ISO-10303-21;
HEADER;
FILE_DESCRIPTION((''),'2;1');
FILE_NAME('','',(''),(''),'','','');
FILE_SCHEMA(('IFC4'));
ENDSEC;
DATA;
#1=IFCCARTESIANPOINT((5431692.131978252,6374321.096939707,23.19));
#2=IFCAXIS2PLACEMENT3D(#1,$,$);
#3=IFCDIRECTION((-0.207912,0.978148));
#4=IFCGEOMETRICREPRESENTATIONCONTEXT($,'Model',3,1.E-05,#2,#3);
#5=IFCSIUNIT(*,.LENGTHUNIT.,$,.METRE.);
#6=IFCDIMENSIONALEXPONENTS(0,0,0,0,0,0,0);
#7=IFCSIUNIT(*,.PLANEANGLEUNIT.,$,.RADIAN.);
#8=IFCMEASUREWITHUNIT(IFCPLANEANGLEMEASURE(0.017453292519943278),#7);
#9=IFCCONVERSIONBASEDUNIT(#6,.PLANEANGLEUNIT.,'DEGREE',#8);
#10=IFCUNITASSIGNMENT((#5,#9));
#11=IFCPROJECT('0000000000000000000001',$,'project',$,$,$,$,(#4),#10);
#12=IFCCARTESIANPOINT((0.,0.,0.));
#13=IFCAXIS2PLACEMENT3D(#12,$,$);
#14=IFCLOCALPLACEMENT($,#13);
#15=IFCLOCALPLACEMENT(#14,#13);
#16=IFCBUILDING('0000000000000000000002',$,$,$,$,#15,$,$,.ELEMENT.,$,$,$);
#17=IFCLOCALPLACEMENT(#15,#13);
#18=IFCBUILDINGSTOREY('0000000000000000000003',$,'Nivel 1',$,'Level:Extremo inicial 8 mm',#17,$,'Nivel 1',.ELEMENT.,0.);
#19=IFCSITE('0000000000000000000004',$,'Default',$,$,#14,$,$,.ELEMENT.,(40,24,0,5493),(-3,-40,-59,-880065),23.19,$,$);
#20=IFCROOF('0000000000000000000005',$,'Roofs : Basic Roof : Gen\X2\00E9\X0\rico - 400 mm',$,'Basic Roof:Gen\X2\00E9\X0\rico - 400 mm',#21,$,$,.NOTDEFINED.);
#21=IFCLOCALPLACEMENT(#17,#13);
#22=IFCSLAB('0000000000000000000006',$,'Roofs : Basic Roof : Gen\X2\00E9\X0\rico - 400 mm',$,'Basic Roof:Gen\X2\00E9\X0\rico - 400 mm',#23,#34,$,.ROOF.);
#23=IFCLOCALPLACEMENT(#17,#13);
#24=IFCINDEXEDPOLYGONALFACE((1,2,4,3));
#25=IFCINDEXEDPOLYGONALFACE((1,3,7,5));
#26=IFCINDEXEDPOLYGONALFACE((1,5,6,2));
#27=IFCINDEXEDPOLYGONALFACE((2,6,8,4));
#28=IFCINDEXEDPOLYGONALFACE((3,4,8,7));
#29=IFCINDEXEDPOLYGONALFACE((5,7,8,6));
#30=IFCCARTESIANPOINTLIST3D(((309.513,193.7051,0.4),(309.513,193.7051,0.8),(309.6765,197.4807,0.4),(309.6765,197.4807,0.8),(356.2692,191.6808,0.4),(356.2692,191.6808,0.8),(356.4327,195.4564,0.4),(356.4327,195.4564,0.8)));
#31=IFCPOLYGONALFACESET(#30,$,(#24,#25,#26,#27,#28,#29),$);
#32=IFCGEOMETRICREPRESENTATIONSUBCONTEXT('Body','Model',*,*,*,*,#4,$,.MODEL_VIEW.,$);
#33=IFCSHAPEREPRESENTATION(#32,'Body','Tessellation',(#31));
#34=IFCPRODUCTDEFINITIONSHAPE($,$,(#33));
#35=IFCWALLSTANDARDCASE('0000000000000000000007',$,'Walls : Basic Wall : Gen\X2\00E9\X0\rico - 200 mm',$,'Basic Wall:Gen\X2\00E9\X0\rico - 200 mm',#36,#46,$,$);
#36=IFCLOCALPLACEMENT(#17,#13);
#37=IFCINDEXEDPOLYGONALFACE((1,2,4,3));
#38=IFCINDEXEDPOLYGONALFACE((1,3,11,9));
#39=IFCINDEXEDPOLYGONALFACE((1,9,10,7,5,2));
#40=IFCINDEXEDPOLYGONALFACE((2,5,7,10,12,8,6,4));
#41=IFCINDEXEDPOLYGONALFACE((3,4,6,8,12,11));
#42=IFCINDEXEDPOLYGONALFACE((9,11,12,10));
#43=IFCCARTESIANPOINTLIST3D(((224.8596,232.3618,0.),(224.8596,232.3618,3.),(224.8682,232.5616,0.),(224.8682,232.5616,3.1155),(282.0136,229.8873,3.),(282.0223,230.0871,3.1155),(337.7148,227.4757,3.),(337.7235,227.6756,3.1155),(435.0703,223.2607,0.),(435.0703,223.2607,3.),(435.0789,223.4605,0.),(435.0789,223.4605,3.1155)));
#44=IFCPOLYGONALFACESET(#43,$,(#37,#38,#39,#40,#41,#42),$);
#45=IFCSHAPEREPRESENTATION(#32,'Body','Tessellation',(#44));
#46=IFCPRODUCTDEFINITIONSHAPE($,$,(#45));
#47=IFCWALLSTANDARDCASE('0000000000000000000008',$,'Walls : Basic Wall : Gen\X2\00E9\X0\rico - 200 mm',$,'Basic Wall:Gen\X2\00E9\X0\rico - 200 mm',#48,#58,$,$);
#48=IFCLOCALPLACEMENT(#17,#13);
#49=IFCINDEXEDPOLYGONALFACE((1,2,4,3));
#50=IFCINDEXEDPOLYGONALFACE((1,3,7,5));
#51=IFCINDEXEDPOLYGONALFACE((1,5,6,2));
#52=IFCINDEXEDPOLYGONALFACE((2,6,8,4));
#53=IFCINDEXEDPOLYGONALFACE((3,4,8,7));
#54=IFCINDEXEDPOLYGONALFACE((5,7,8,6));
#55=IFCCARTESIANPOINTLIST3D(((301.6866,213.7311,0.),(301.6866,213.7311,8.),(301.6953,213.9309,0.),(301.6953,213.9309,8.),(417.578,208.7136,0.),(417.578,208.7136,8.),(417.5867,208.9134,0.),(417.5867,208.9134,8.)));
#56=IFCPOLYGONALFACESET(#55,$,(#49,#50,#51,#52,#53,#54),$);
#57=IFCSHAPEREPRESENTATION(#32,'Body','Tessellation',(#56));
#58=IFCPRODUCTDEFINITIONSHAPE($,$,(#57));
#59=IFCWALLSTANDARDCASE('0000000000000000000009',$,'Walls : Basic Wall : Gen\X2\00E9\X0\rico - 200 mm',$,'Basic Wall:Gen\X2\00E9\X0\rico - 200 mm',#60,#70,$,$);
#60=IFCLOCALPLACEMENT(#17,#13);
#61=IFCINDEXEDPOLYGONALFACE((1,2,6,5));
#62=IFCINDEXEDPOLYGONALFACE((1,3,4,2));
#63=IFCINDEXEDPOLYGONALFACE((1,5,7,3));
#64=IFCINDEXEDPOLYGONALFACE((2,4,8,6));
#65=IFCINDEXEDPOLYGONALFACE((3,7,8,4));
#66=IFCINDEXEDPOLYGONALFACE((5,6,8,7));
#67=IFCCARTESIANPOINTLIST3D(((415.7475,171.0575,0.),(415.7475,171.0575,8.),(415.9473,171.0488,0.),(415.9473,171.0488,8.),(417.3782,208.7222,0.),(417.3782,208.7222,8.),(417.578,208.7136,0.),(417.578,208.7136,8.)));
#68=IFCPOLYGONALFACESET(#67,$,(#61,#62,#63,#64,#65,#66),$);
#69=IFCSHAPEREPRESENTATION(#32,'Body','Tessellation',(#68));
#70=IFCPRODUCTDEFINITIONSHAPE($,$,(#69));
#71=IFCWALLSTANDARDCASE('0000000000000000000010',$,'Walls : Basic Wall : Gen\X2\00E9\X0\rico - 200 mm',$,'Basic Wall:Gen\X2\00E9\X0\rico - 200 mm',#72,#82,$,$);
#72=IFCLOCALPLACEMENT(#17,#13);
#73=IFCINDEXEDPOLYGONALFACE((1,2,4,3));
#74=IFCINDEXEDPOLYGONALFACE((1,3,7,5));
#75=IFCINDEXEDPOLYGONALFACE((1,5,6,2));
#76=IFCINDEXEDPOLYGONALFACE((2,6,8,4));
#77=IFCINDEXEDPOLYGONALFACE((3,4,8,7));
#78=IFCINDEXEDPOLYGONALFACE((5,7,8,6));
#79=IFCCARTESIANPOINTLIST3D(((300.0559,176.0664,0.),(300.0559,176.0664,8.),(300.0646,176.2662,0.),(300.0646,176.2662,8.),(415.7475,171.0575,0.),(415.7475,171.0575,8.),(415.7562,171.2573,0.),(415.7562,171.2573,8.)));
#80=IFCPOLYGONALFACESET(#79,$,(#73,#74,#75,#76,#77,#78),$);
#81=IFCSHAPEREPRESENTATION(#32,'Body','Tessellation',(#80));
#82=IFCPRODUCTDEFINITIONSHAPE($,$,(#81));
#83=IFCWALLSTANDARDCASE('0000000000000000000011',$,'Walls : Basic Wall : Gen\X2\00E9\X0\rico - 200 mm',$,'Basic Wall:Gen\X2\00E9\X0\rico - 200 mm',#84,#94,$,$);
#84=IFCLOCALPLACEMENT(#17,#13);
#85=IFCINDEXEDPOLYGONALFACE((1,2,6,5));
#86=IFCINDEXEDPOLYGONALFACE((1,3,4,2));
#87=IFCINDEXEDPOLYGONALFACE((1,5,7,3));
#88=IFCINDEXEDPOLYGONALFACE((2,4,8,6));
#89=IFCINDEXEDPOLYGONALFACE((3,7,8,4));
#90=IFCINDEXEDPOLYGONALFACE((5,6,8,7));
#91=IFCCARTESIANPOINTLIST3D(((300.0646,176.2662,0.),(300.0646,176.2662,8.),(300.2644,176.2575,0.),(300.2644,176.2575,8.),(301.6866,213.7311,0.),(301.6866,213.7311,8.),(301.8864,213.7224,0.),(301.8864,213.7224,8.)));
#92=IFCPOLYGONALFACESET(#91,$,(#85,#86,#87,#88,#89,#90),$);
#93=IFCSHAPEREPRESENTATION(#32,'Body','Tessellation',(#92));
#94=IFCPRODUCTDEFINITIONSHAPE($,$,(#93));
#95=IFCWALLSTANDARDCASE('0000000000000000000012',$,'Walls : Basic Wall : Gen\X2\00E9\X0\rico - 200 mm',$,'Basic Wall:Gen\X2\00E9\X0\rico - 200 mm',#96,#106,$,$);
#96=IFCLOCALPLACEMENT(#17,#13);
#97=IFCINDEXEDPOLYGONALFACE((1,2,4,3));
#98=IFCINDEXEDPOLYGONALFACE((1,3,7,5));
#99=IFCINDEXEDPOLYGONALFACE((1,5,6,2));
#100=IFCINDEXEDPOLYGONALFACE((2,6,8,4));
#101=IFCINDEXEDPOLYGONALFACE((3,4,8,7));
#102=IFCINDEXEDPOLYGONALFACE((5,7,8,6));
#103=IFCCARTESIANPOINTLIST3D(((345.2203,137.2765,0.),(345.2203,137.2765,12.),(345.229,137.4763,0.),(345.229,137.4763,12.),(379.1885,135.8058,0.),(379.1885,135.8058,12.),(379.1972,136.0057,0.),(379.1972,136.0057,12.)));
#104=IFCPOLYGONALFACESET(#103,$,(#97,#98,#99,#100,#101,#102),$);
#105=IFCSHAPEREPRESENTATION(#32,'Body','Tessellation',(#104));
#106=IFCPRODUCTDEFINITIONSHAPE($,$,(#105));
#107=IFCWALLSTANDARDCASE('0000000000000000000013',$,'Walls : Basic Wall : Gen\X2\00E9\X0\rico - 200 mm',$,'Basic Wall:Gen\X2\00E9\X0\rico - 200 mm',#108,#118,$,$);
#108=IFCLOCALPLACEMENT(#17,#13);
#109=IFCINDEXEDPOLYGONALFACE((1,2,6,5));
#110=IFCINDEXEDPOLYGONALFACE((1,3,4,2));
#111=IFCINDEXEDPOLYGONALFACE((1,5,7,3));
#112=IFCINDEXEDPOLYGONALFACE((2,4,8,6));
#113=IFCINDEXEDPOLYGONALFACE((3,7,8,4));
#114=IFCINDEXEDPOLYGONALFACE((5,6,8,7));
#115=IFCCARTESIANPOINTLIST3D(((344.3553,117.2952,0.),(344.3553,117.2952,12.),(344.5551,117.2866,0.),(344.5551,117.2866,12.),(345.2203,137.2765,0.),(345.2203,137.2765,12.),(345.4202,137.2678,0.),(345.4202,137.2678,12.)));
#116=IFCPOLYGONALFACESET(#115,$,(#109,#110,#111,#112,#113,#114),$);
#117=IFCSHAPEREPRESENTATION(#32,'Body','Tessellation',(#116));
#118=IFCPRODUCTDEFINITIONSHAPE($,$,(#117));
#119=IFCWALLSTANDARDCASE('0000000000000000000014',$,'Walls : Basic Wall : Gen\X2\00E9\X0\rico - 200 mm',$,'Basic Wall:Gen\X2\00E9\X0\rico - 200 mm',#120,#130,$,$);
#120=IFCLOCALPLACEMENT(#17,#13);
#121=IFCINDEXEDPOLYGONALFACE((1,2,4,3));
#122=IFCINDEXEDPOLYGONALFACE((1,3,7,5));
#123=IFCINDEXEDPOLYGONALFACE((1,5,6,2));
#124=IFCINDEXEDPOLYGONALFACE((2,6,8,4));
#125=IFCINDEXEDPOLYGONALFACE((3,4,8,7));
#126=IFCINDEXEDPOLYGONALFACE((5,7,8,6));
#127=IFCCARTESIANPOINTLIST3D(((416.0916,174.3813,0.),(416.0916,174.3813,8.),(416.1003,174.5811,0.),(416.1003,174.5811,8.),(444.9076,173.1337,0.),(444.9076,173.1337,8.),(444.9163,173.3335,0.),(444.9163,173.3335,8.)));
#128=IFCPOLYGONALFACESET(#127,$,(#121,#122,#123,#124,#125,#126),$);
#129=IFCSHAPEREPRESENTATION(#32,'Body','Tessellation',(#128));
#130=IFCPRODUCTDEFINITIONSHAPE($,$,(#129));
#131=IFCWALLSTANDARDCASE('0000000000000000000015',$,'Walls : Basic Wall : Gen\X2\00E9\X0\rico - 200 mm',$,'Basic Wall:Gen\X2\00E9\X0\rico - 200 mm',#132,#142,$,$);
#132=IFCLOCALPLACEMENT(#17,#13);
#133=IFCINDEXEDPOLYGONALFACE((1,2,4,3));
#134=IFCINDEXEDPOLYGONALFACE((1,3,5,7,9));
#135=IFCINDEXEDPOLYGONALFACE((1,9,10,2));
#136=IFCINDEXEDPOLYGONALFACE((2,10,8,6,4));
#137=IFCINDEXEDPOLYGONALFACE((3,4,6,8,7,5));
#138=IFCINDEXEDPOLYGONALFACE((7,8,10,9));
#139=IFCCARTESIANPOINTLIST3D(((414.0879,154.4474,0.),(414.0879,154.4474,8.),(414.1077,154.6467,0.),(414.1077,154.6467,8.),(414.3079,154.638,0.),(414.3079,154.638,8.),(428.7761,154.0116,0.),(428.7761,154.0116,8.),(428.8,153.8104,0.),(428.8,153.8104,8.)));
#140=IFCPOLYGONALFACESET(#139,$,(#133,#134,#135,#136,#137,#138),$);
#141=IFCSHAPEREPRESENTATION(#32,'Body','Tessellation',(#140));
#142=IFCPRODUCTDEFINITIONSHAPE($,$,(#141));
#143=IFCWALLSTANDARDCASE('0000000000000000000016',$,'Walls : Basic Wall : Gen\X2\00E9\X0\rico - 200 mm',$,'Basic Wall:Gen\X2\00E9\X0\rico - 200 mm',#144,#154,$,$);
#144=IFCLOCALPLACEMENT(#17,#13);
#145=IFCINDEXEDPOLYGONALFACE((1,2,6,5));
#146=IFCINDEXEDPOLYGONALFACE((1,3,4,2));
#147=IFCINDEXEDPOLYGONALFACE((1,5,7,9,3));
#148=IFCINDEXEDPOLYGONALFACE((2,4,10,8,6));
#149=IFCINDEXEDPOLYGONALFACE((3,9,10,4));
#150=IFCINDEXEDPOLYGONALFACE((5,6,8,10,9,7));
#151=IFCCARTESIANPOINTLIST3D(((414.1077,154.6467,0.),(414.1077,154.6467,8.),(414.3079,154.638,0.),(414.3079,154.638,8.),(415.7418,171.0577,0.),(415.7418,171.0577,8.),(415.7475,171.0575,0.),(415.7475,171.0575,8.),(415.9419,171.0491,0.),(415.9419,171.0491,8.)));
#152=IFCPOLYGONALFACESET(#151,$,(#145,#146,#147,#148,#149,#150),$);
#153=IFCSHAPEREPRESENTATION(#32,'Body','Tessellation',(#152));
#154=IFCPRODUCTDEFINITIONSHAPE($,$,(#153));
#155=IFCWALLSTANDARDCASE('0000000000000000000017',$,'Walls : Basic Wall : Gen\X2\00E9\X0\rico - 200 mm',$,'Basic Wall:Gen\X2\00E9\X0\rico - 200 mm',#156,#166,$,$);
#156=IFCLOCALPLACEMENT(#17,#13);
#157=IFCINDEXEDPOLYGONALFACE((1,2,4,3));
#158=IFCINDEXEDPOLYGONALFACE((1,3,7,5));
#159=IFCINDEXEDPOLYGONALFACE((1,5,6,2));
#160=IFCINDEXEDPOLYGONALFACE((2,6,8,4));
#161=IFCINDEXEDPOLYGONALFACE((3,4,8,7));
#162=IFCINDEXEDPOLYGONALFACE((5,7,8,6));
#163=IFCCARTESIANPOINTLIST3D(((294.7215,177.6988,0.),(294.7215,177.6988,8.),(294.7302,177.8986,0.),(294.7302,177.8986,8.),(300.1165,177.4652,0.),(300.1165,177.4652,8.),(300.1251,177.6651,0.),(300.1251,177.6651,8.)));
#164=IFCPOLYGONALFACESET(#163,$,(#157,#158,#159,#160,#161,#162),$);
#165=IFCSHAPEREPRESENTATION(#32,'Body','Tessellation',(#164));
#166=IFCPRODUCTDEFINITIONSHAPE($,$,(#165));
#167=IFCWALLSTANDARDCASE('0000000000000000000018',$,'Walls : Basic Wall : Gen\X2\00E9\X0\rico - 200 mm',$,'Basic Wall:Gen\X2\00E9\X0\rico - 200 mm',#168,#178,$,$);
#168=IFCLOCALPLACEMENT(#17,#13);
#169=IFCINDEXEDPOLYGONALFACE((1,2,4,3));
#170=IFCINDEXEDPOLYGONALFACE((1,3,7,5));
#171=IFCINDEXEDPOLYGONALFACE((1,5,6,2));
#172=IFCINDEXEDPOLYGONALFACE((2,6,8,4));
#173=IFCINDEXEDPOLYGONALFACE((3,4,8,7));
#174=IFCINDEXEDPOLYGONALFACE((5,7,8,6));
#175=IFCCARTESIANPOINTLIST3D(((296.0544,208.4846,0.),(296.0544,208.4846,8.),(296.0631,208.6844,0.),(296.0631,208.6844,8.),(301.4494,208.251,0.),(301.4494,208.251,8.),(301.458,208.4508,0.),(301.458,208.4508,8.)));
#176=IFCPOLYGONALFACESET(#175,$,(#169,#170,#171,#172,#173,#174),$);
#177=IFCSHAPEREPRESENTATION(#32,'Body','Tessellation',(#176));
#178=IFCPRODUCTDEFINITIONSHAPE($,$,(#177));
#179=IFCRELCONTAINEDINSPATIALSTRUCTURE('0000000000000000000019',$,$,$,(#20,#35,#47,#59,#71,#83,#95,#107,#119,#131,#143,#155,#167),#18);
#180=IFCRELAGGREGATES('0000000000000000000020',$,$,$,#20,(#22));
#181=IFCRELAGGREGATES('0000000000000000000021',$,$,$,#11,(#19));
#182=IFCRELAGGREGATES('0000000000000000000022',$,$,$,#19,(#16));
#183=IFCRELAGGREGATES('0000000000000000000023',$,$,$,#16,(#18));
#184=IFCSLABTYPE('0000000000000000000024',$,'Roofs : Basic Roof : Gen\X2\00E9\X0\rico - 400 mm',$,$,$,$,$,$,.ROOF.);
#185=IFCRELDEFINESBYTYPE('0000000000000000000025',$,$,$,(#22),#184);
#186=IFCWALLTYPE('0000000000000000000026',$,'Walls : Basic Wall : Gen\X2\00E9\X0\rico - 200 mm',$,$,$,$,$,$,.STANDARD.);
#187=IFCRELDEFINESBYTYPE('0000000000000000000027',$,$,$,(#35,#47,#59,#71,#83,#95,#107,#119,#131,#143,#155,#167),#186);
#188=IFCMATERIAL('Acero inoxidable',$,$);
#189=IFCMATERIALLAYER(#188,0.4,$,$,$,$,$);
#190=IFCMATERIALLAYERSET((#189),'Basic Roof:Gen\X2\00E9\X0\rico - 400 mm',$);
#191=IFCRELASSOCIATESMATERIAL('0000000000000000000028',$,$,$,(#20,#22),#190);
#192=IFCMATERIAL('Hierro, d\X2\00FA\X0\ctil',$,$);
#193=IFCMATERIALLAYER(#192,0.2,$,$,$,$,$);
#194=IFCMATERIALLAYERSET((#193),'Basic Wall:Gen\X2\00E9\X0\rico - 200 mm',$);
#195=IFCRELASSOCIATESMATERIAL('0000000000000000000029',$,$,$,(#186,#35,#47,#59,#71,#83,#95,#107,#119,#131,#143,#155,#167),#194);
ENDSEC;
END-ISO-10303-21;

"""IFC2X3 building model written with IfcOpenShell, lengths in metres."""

from ifc_helpers import new_model, entity, si_unit, converted_unit, direction, frame, frame_2d, origin, place, context, subcontext, project, spatial, polyline, rectangle, outline, extrude, clip, bounded_halfspace, material, layer, layer_set, layer_usage, type_object, element, aggregate, save


model = new_model("IFC2X3")

# Units and contexts
model_context = context("Model", 3, precision=1e-05, world=frame((5431692.131978252, 6374321.096939707, 23.19)), true_north=direction((-0.207912, 0.978148)))
body_context = subcontext(model_context, "Body", "Model", "MODEL_VIEW")
ifc_project = project(units=[si_unit("LENGTHUNIT", "METRE"), converted_unit("PLANEANGLEUNIT", "DEGREE", entity("IfcPlaneAngleMeasure", 0.017453292519943278), si_unit("PLANEANGLEUNIT", "RADIAN"), dimensions=[0, 0, 0, 0, 0, 0, 0])], contexts=[model_context])

# Site, building, storey
site_placement = place(None, origin())
site = spatial("IfcSite", under=ifc_project, at=site_placement, Name="Default", CompositionType="ELEMENT", RefLatitude=(40, 24, 0, 5493), RefLongitude=(-3, -40, -59, -880065), RefElevation=23.19)
building_placement = place(site_placement, origin())
building = spatial("IfcBuilding", under=site, at=building_placement, CompositionType="ELEMENT")
storey_placement = place(building_placement, origin())
storey = spatial("IfcBuildingStorey", under=building, at=storey_placement, Name="Nivel 1", ObjectType="Level:Extremo inicial 8 mm", LongName="Nivel 1", CompositionType="ELEMENT", Elevation=0.0)

# Roof, slab
ifc_material_1 = material(Name="Acero inoxidable")
ifc_layer_1 = layer(ifc_material_1, 0.4)
ifc_layer_set_1 = layer_set([ifc_layer_1], Name="Basic Roof:Genérico - 400 mm")
roof_placement = place(storey_placement, frame((309.513, 191.6808, 0.4)))
roof = element("IfcRoof", 1, at=roof_placement, inside=storey, material=ifc_layer_set_1, Name="Roofs : Basic Roof : Genérico - 400 mm", ObjectType="Basic Roof:Genérico - 400 mm", ShapeType="NOTDEFINED")
slab_type = type_object("IfcSlabType", Name="Roofs : Basic Roof : Genérico - 400 mm", PredefinedType="ROOF")
slab_placement = place(roof_placement, origin())
slab = element("IfcSlab", 2, at=slab_placement, type_object=slab_type, material=ifc_layer_set_1, Name="Roofs : Basic Roof : Genérico - 400 mm", ObjectType="Basic Roof:Genérico - 400 mm", PredefinedType="ROOF", context=body_context, shape_type="SweptSolid", body=[
    extrude(rectangle(XDim=3.7792, YDim=46.8, at=frame_2d((0.0, 0.0), x_axis=(0.043255, 0.999064))), frame((23.4598, 2.9, 0.0)), (0.0, 0.0, 1.0), 0.4),
])
aggregate(roof, [slab])

# Walls
ifc_material_2 = material(Name="Hierro, dúctil")
ifc_layer_2 = layer(ifc_material_2, 0.2)
ifc_layer_set_2 = layer_set([ifc_layer_2], Name="Basic Wall:Genérico - 200 mm")
ifc_layer_usage_1 = layer_usage(ifc_layer_set_2, "AXIS2", "NEGATIVE", 0.1)
wall_type = type_object("IfcWallType", Name="Walls : Basic Wall : Genérico - 200 mm", PredefinedType="STANDARD", material=ifc_layer_set_2)
wall_1_placement = place(storey_placement, frame((435.0746, 223.3606, 0.0), z_axis=(0.0, 0.0, 1.0), x_axis=(-0.999064, 0.043255, 0.0)))
element("IfcWallStandardCase", 3, at=wall_1_placement, inside=storey, type_object=wall_type, material=ifc_layer_usage_1, Name="Walls : Basic Wall : Genérico - 200 mm", ObjectType="Basic Wall:Genérico - 200 mm", context=body_context, shape_type="Clipping", body=[
    clip(clip(clip(extrude(rectangle(XDim=210.4076, YDim=0.2, at=frame_2d((105.2038, 0.0), x_axis=(-1.0, 0.0))), origin(), (0.0, 0.0, 1.0), 3.1155), bounded_halfspace(frame((153.2, -0.1, 3.1155), z_axis=(0.0, 0.5, 0.866025), x_axis=(-1.0, 0.0, 0.0)), False, frame((153.2, -0.1, 3.1155)), polyline([(0.0, 0.0), (57.0076, 0.0), (57.2076, 0.0), (57.2076, 0.2), (0.0, 0.2), (0.0, 0.0)]))), bounded_halfspace(frame((153.2, -0.1, 3.1155), z_axis=(0.0, 0.5, 0.866025), x_axis=(-1.0, 0.0, 0.0)), False, frame((153.2, -0.1, 3.1155)), polyline([(0.0, 0.0), (0.0, 0.2), (-55.7534, 0.2), (-55.7534, 0.0), (0.0, 0.0)]))), bounded_halfspace(frame((0.0, -0.1, 3.1155), z_axis=(0.0, 0.5, 0.866025), x_axis=(-1.0, 0.0, 0.0)), False, frame((0.0, -0.1, 3.1155)), polyline([(0.0, 0.0), (97.4466, 0.0), (97.4466, 0.2), (0.0, 0.2), (0.0, 0.0)]))),
])
ifc_layer_usage_2 = layer_usage(ifc_layer_set_2, "AXIS2", "NEGATIVE", 0.1)
wall_2_placement = place(storey_placement, frame((301.6909, 213.831, 0.0), z_axis=(0.0, 0.0, 1.0), x_axis=(0.999064, -0.043255, 0.0)))
element("IfcWallStandardCase", 4, at=wall_2_placement, inside=storey, type_object=wall_type, material=ifc_layer_usage_2, Name="Walls : Basic Wall : Genérico - 200 mm", ObjectType="Basic Wall:Genérico - 200 mm", context=body_context, shape_type="SweptSolid", body=[
    extrude(rectangle(XDim=116.0, YDim=0.2, at=frame_2d((58.0, 0.0), x_axis=(-1.0, 0.0))), origin(), (0.0, 0.0, 1.0), 8.0),
])
ifc_layer_usage_3 = layer_usage(ifc_layer_set_2, "AXIS2", "NEGATIVE", 0.1)
wall_3_placement = place(storey_placement, frame((417.4781, 208.7179, 0.0), z_axis=(0.0, 0.0, 1.0), x_axis=(-0.043255, -0.999064, 0.0)))
element("IfcWallStandardCase", 5, at=wall_3_placement, inside=storey, type_object=wall_type, material=ifc_layer_usage_3, Name="Walls : Basic Wall : Genérico - 200 mm", ObjectType="Basic Wall:Genérico - 200 mm", context=body_context, shape_type="Clipping", body=[
    clip(extrude(rectangle(XDim=37.7, YDim=0.2, at=frame_2d((18.85, 0.0), x_axis=(-1.0, 0.0))), origin(), (0.0, 0.0, 1.0), 8.0), bounded_halfspace(frame((26.4644, -0.1, 8.0), z_axis=(0.0, 0.0, 1.0), x_axis=(-0.043255, 0.999064, 0.0)), False, frame((26.4644, -0.1, 8.0)), polyline([(0.0, 0.0), (11.0356, 0.0), (11.0356, 0.2), (7.9, 0.2), (7.7, 0.2), (0.0, 0.2), (0.0, 0.0)]))),
])
ifc_layer_usage_4 = layer_usage(ifc_layer_set_2, "AXIS2", "NEGATIVE", 0.1)
wall_4_placement = place(storey_placement, frame((415.7519, 171.1574, 0.0), z_axis=(0.0, 0.0, 1.0), x_axis=(-0.999064, 0.043255, 0.0)))
element("IfcWallStandardCase", 6, at=wall_4_placement, inside=storey, type_object=wall_type, material=ifc_layer_usage_4, Name="Walls : Basic Wall : Genérico - 200 mm", ObjectType="Basic Wall:Genérico - 200 mm", context=body_context, shape_type="SweptSolid", body=[
    extrude(rectangle(XDim=115.8, YDim=0.2, at=frame_2d((57.9, 0.0), x_axis=(-1.0, 0.0))), origin(), (0.0, 0.0, 1.0), 8.0),
])
ifc_layer_usage_5 = layer_usage(ifc_layer_set_2, "AXIS2", "NEGATIVE", 0.1)
wall_5_placement = place(storey_placement, frame((300.1645, 176.2619, 0.0), z_axis=(0.0, 0.0, 1.0), x_axis=(0.043255, 0.999064, 0.0)))
element("IfcWallStandardCase", 7, at=wall_5_placement, inside=storey, type_object=wall_type, material=ifc_layer_usage_5, Name="Walls : Basic Wall : Genérico - 200 mm", ObjectType="Basic Wall:Genérico - 200 mm", context=body_context, shape_type="SweptSolid", body=[
    extrude(rectangle(XDim=37.5, YDim=0.2, at=frame_2d((18.75, 0.0), x_axis=(-1.0, 0.0))), origin(), (0.0, 0.0, 1.0), 8.0),
])
ifc_layer_usage_6 = layer_usage(ifc_layer_set_2, "AXIS2", "NEGATIVE", 0.1)
wall_6_placement = place(storey_placement, frame((345.2247, 137.3764, 0.0), z_axis=(0.0, 0.0, 1.0), x_axis=(0.999064, -0.043255, 0.0)))
element("IfcWallStandardCase", 8, at=wall_6_placement, inside=storey, type_object=wall_type, material=ifc_layer_usage_6, Name="Walls : Basic Wall : Genérico - 200 mm", ObjectType="Basic Wall:Genérico - 200 mm", context=body_context, shape_type="SweptSolid", body=[
    extrude(rectangle(XDim=34.0, YDim=0.2, at=frame_2d((17.0, 0.0), x_axis=(-1.0, 0.0))), origin(), (0.0, 0.0, 1.0), 12.0),
])
ifc_layer_usage_7 = layer_usage(ifc_layer_set_2, "AXIS2", "NEGATIVE", 0.1)
wall_7_placement = place(storey_placement, frame((345.3203, 137.2722, 0.0), z_axis=(0.0, 0.0, 1.0), x_axis=(-0.043255, -0.999064, 0.0)))
element("IfcWallStandardCase", 9, at=wall_7_placement, inside=storey, type_object=wall_type, material=ifc_layer_usage_7, Name="Walls : Basic Wall : Genérico - 200 mm", ObjectType="Basic Wall:Genérico - 200 mm", context=body_context, shape_type="SweptSolid", body=[
    extrude(rectangle(XDim=20.0, YDim=0.2, at=frame_2d((10.0, 0.0), x_axis=(-1.0, 0.0))), origin(), (0.0, 0.0, 1.0), 12.0),
])
ifc_layer_usage_8 = layer_usage(ifc_layer_set_2, "AXIS2", "NEGATIVE", 0.1)
wall_8_placement = place(storey_placement, frame((416.096, 174.4812, 0.0), z_axis=(0.0, 0.0, 1.0), x_axis=(0.999064, -0.043255, 0.0)))
element("IfcWallStandardCase", 10, at=wall_8_placement, inside=storey, type_object=wall_type, material=ifc_layer_usage_8, Name="Walls : Basic Wall : Genérico - 200 mm", ObjectType="Basic Wall:Genérico - 200 mm", context=body_context, shape_type="SweptSolid", body=[
    extrude(rectangle(XDim=28.843, YDim=0.2, at=frame_2d((14.4215, 0.0), x_axis=(-1.0, 0.0))), origin(), (0.0, 0.0, 1.0), 8.0),
])
ifc_layer_usage_9 = layer_usage(ifc_layer_set_2, "AXIS2", "NEGATIVE", 0.1)
wall_9_placement = place(storey_placement, frame((428.8043, 153.9103, 0.0), z_axis=(0.0, 0.0, 1.0), x_axis=(-0.999064, 0.043255, 0.0)))
element("IfcWallStandardCase", 11, at=wall_9_placement, inside=storey, type_object=wall_type, material=ifc_layer_usage_9, Name="Walls : Basic Wall : Genérico - 200 mm", ObjectType="Basic Wall:Genérico - 200 mm", context=body_context, shape_type="SweptSolid", body=[
    extrude(outline(polyline([(14.7146, -0.1), (14.7258, 0.1), (0.0, 0.1), (0.0326, -0.1), (14.5143, -0.1), (14.7146, -0.1)])), origin(), (0.0, 0.0, 1.0), 8.0),
])
ifc_layer_usage_10 = layer_usage(ifc_layer_set_2, "AXIS2", "NEGATIVE", 0.1)
wall_10_placement = place(storey_placement, frame((414.2073, 154.6368, 0.0), z_axis=(0.0, 0.0, 1.0), x_axis=(0.099079, 0.99508, 0.0)))
element("IfcWallStandardCase", 12, at=wall_10_placement, inside=storey, type_object=wall_type, material=ifc_layer_usage_10, Name="Walls : Basic Wall : Genérico - 200 mm", ObjectType="Basic Wall:Genérico - 200 mm", context=body_context, shape_type="SweptSolid", body=[
    extrude(outline(polyline([(16.5034, -0.1), (16.4925, 0.0942), (16.4922, 0.1), (0.0, 0.1), (0.0112, -0.1), (16.5034, -0.1)])), origin(), (0.0, 0.0, 1.0), 8.0),
])
ifc_layer_usage_11 = layer_usage(ifc_layer_set_2, "AXIS2", "NEGATIVE", 0.1)
wall_11_placement = place(storey_placement, frame((300.1208, 177.5652, 0.0), z_axis=(0.0, 0.0, 1.0), x_axis=(-0.999064, 0.043255, 0.0)))
element("IfcWallStandardCase", 13, at=wall_11_placement, inside=storey, type_object=wall_type, material=ifc_layer_usage_11, Name="Walls : Basic Wall : Genérico - 200 mm", ObjectType="Basic Wall:Genérico - 200 mm", context=body_context, shape_type="SweptSolid", body=[
    extrude(rectangle(XDim=5.4, YDim=0.2, at=frame_2d((2.7, 0.0), x_axis=(-1.0, 0.0))), origin(), (0.0, 0.0, 1.0), 8.0),
])
ifc_layer_usage_12 = layer_usage(ifc_layer_set_2, "AXIS2", "NEGATIVE", 0.1)
wall_12_placement = place(storey_placement, frame((296.0587, 208.5845, 0.0), z_axis=(0.0, 0.0, 1.0), x_axis=(0.999064, -0.043255, 0.0)))
element("IfcWallStandardCase", 14, at=wall_12_placement, inside=storey, type_object=wall_type, material=ifc_layer_usage_12, Name="Walls : Basic Wall : Genérico - 200 mm", ObjectType="Basic Wall:Genérico - 200 mm", context=body_context, shape_type="Clipping", body=[
    clip(extrude(rectangle(XDim=5.4, YDim=0.2, at=frame_2d((2.7, 0.0), x_axis=(-1.0, 0.0))), origin(), (0.0, 0.0, 1.0), 8.0), bounded_halfspace(frame((0.2, -0.1, 8.0), z_axis=(0.0, 0.0, 1.0), x_axis=(0.999064, 0.043255, 0.0)), False, frame((0.2, -0.1, 8.0)), polyline([(0.0, 0.0), (5.2, 0.0), (5.2, 0.2), (0.0, 0.2), (0.0, 0.0)]))),
])

save(model, "model.ifc")
